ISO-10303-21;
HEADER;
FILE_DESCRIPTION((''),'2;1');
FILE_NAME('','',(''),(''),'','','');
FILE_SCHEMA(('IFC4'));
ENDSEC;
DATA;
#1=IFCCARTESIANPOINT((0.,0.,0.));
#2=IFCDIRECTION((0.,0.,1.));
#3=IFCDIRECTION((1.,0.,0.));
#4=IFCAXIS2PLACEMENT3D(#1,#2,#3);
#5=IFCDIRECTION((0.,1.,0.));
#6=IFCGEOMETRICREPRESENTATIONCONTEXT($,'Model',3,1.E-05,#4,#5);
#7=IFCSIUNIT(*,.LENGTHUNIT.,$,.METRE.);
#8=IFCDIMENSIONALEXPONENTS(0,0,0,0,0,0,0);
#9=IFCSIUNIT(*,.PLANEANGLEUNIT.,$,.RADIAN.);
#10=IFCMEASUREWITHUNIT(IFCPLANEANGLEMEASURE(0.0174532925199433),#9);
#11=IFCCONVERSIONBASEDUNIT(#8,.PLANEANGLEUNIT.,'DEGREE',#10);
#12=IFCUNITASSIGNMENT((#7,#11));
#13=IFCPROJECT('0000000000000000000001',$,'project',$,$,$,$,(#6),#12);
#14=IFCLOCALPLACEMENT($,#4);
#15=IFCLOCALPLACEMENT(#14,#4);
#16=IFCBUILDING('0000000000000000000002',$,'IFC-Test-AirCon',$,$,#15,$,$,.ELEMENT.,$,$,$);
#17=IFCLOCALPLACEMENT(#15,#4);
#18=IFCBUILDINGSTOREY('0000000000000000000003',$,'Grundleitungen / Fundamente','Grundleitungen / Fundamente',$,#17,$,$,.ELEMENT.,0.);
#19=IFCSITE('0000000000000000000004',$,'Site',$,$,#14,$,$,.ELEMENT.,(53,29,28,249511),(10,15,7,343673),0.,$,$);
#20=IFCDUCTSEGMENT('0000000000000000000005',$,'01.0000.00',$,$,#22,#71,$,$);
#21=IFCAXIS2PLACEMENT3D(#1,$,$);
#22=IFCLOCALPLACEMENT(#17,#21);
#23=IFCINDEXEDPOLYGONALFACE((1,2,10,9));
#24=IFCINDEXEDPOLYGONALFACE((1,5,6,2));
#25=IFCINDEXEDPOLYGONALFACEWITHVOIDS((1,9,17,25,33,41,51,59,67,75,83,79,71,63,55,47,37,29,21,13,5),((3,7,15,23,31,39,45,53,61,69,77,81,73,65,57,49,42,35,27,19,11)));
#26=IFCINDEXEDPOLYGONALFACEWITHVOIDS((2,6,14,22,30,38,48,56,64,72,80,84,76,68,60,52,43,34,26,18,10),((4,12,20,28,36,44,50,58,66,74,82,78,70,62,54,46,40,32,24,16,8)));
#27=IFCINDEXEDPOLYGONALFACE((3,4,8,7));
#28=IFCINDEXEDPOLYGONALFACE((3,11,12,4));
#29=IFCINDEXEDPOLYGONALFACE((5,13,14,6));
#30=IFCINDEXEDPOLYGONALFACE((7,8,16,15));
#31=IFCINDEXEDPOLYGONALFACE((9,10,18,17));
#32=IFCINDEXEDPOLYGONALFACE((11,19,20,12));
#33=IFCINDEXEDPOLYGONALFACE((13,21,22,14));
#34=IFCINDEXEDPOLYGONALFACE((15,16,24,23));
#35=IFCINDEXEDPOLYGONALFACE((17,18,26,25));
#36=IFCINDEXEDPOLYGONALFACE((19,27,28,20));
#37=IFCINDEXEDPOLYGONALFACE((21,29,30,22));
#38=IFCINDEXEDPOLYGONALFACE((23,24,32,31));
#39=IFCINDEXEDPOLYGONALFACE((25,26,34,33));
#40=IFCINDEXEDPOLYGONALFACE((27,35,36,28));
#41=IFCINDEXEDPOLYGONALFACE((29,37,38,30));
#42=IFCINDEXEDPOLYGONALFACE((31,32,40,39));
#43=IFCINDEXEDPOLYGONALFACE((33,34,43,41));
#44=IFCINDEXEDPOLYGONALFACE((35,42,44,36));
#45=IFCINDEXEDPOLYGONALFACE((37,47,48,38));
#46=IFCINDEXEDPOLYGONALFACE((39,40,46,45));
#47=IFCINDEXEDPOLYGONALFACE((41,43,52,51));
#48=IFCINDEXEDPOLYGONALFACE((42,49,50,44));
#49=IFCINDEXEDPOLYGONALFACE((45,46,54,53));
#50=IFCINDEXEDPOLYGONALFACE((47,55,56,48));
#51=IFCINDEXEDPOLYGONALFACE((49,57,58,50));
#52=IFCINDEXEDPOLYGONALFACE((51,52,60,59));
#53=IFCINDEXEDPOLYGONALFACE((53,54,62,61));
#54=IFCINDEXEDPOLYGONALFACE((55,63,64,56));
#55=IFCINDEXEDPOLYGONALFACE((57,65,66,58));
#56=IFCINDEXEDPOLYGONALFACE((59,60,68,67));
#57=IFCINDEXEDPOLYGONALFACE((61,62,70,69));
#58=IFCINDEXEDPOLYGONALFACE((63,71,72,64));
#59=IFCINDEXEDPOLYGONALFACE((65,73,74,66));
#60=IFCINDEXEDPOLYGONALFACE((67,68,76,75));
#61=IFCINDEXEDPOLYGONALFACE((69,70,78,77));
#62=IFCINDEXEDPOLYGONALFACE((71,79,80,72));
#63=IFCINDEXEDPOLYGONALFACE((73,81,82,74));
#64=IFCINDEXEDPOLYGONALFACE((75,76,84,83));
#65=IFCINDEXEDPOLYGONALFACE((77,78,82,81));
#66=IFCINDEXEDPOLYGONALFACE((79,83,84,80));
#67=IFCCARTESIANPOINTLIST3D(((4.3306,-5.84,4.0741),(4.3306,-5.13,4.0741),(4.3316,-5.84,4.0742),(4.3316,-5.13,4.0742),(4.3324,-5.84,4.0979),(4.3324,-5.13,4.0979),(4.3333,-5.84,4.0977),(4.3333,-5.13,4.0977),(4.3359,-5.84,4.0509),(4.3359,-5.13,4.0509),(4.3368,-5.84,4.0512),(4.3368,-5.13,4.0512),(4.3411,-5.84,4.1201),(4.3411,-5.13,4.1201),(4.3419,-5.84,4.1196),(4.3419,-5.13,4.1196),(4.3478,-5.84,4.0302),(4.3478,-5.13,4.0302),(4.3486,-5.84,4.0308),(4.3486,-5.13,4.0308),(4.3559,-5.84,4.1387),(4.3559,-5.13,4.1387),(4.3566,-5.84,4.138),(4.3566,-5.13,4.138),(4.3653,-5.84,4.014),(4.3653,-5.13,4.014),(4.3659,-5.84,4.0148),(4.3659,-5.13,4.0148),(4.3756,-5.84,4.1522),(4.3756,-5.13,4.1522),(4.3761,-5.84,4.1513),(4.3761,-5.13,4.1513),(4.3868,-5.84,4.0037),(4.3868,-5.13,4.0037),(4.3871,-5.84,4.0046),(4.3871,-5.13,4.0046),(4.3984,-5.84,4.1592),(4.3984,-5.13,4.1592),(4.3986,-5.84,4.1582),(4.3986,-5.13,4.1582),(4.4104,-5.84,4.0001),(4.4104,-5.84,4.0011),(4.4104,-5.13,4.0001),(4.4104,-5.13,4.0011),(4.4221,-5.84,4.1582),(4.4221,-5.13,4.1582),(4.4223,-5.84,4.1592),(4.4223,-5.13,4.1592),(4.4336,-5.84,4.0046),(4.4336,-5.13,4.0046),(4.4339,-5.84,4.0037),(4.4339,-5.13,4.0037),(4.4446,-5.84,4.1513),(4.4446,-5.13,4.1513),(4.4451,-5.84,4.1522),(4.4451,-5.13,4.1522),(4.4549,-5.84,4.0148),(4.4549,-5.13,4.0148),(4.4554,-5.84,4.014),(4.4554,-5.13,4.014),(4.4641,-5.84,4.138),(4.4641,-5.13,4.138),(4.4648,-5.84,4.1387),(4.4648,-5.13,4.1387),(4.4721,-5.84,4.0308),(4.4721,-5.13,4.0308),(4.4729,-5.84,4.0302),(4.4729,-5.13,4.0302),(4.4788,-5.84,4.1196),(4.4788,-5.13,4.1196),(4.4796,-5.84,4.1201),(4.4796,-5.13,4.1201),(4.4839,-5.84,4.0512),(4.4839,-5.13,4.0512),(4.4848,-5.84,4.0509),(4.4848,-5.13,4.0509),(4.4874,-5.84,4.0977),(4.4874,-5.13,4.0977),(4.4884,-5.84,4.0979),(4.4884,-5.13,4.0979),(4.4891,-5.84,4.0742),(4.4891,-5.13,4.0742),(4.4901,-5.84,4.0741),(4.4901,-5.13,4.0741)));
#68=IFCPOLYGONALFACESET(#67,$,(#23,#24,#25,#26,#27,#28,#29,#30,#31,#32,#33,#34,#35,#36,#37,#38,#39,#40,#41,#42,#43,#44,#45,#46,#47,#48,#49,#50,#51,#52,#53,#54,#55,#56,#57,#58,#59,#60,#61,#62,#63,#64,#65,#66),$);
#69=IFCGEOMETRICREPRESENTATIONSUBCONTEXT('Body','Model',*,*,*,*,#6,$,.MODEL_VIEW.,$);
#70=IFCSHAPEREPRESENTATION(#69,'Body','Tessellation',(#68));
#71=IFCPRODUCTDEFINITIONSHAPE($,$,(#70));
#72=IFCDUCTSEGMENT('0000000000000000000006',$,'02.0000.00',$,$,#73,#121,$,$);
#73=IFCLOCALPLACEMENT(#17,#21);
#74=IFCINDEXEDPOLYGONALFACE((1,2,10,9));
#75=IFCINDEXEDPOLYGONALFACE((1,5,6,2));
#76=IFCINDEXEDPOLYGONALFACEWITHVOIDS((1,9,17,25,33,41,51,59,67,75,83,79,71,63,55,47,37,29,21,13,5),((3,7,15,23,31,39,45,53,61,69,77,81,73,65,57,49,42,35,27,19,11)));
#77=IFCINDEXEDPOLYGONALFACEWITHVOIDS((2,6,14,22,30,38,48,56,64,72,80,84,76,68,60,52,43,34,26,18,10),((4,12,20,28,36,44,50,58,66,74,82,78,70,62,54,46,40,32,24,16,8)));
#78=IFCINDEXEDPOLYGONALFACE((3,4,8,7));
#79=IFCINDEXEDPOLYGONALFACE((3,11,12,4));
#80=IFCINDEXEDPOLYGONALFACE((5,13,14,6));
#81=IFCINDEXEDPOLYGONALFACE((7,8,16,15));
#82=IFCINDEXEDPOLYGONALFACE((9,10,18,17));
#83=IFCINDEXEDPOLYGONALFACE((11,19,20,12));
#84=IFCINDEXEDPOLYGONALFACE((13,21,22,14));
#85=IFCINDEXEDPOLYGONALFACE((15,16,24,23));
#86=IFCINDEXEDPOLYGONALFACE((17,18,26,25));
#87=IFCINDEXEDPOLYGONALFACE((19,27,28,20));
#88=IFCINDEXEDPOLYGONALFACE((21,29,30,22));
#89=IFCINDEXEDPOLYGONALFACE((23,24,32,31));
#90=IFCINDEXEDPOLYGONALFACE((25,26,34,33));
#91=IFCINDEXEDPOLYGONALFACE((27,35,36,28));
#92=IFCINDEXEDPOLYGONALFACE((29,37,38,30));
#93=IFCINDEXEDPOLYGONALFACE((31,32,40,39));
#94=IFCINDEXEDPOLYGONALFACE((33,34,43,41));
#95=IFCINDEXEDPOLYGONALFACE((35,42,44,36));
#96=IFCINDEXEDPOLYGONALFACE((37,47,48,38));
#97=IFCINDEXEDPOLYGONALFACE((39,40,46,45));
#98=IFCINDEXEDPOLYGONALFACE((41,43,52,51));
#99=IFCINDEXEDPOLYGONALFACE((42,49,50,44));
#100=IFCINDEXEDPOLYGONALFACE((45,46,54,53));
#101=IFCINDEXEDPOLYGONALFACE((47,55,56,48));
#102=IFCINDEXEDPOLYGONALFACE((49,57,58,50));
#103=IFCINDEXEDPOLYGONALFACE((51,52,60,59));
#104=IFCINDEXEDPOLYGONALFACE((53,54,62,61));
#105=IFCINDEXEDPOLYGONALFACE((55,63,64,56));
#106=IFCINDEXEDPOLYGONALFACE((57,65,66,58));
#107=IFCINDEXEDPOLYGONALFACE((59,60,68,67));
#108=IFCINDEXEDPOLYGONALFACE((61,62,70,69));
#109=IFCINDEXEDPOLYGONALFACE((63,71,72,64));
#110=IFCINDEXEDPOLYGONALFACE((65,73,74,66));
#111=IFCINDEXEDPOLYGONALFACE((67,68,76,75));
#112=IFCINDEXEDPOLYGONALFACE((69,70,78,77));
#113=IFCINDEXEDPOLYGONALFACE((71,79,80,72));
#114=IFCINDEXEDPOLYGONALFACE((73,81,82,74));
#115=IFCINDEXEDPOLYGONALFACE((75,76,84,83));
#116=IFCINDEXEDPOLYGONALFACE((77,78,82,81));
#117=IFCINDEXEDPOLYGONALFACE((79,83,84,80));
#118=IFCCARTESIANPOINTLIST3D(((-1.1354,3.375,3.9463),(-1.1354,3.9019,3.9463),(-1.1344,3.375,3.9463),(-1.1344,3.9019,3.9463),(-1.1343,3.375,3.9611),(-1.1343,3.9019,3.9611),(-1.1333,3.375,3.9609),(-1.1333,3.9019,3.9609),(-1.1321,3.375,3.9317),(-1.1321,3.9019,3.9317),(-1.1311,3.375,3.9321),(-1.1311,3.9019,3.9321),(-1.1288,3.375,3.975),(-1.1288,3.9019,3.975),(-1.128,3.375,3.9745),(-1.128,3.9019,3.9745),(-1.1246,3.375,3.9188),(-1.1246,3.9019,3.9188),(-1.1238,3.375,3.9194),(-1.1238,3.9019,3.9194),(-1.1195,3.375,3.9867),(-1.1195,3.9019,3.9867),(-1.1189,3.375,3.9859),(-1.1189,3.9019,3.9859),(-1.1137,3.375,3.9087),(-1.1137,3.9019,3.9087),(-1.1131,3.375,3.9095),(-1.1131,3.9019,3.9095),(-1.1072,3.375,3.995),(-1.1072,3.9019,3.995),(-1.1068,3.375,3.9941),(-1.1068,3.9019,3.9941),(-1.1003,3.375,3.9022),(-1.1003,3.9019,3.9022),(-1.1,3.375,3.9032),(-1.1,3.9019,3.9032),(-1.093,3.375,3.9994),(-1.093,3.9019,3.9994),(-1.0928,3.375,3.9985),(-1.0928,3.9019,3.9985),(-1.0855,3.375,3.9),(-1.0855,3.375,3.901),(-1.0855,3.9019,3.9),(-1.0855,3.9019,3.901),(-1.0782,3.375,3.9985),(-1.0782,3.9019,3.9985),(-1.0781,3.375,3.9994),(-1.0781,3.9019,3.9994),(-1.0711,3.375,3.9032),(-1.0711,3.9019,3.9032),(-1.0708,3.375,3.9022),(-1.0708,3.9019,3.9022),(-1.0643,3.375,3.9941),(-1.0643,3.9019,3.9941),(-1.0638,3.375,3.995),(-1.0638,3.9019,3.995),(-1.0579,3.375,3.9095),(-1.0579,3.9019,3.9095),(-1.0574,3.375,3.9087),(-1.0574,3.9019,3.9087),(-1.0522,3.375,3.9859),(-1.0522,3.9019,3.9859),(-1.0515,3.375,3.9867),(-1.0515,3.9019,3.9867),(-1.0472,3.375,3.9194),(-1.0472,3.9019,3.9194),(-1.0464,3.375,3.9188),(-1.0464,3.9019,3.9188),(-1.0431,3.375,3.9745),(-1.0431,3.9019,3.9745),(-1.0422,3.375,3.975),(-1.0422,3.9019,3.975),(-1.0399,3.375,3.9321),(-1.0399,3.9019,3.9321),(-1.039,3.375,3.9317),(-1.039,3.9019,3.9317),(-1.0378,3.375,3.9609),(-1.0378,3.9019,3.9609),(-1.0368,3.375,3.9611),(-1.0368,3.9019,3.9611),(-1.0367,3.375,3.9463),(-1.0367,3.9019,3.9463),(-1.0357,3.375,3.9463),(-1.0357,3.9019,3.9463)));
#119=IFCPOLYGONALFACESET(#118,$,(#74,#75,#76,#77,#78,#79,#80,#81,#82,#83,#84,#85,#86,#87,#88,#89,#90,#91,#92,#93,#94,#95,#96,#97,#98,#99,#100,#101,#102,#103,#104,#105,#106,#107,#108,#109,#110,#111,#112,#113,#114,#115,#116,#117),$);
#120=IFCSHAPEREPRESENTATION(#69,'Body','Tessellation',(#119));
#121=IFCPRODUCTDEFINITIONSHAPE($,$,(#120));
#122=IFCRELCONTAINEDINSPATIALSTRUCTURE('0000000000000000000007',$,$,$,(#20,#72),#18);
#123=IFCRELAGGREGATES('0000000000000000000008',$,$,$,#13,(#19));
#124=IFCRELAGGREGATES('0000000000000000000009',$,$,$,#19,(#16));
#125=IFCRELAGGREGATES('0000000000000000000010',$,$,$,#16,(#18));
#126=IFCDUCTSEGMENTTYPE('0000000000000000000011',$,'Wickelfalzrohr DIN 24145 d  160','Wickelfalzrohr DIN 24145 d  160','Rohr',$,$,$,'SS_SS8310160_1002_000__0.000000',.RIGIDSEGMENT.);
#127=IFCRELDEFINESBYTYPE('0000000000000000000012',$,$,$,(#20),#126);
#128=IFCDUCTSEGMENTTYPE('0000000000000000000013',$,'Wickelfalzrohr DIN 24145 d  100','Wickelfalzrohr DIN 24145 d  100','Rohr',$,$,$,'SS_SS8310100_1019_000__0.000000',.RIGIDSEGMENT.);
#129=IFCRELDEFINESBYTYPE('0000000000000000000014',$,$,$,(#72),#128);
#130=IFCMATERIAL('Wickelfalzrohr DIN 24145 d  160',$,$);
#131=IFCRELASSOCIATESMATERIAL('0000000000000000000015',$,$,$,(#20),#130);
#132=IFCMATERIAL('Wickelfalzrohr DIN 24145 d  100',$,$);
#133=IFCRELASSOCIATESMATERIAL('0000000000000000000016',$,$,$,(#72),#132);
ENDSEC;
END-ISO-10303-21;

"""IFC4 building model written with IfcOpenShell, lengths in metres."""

from ifc_helpers import new_model, entity, si_unit, converted_unit, direction, frame, origin_with_axes, origin_2d_with_axis, place, context, subcontext, project, spatial, hollow_circle, extrude, material, type_object, element, save


model = new_model("IFC4")

# Units and contexts
model_context = context("Model", 3, precision=1e-05, world=origin_with_axes(), true_north=direction((0.0, 1.0, 0.0)))
body_context = subcontext(model_context, "Body", "Model", "MODEL_VIEW")
ifc_project = project(units=[si_unit("LENGTHUNIT", "METRE"), converted_unit("PLANEANGLEUNIT", "DEGREE", entity("IfcPlaneAngleMeasure", 0.0174532925199433), si_unit("PLANEANGLEUNIT", "RADIAN"), dimensions=[0, 0, 0, 0, 0, 0, 0])], contexts=[model_context])

# Site, building, storey
site_placement = place(None, origin_with_axes())
site = spatial("IfcSite", under=ifc_project, at=site_placement, Name="Site", CompositionType="ELEMENT", RefLatitude=(53, 29, 28, 249511), RefLongitude=(10, 15, 7, 343673), RefElevation=0.0)
building_placement = place(site_placement, origin_with_axes())
building = spatial("IfcBuilding", under=site, at=building_placement, Name="IFC-Test-AirCon", CompositionType="ELEMENT")
storey_placement = place(building_placement, origin_with_axes())
storey = spatial("IfcBuildingStorey", under=building, at=storey_placement, Name="Grundleitungen / Fundamente", Description="Grundleitungen / Fundamente", CompositionType="ELEMENT", Elevation=0.0)

# Duct segments
ifc_material_1 = material(Name="Wickelfalzrohr DIN 24145 d  160")
duct_segment_type_1 = type_object("IfcDuctSegmentType", Name="Wickelfalzrohr DIN 24145 d  160", Description="Wickelfalzrohr DIN 24145 d  160", ApplicableOccurrence="Rohr", ElementType="SS_SS8310160_1002_000__0.000000", PredefinedType="RIGIDSEGMENT")
for number, where, z_axis, x_axis, name in (
    (1, (4.4104, -5.84, 4.0801), (0.0, 0.0, 1.0), (0.0, 1.0, 0.0), "01.0000.00"),
):
    element("IfcDuctSegment", number, at=place(storey_placement, frame(where, z_axis=z_axis, x_axis=x_axis)), inside=storey, type_object=duct_segment_type_1, material=ifc_material_1, Name=name, context=body_context, shape_type="SweptSolid", body=[
        extrude(hollow_circle(Radius=0.08, WallThickness=0.001, at=origin_2d_with_axis()), frame((0.0, 0.0, 0.0), z_axis=(1.0, 0.0, 0.0), x_axis=(0.0, 0.0, -1.0)), (0.0, 0.0, 1.0), 0.71),
    ])
ifc_material_2 = material(Name="Wickelfalzrohr DIN 24145 d  100")
duct_segment_type_2 = type_object("IfcDuctSegmentType", Name="Wickelfalzrohr DIN 24145 d  100", Description="Wickelfalzrohr DIN 24145 d  100", ApplicableOccurrence="Rohr", ElementType="SS_SS8310100_1019_000__0.000000", PredefinedType="RIGIDSEGMENT")
duct_segment_1_placement = place(storey_placement, frame((-1.0855, 3.375, 3.95), z_axis=(0.0, 0.0, 1.0), x_axis=(0.0, 1.0, 0.0)))
element("IfcDuctSegment", 2, at=duct_segment_1_placement, inside=storey, type_object=duct_segment_type_2, material=ifc_material_2, Name="02.0000.00", context=body_context, shape_type="SweptSolid", body=[
    extrude(hollow_circle(Radius=0.05, WallThickness=0.001, at=origin_2d_with_axis()), frame((0.0, 0.0, 0.0), z_axis=(1.0, 0.0, 0.0), x_axis=(0.0, 0.0, -1.0)), (0.0, 0.0, 1.0), 0.5269),
])

save(model, "model.ifc")
